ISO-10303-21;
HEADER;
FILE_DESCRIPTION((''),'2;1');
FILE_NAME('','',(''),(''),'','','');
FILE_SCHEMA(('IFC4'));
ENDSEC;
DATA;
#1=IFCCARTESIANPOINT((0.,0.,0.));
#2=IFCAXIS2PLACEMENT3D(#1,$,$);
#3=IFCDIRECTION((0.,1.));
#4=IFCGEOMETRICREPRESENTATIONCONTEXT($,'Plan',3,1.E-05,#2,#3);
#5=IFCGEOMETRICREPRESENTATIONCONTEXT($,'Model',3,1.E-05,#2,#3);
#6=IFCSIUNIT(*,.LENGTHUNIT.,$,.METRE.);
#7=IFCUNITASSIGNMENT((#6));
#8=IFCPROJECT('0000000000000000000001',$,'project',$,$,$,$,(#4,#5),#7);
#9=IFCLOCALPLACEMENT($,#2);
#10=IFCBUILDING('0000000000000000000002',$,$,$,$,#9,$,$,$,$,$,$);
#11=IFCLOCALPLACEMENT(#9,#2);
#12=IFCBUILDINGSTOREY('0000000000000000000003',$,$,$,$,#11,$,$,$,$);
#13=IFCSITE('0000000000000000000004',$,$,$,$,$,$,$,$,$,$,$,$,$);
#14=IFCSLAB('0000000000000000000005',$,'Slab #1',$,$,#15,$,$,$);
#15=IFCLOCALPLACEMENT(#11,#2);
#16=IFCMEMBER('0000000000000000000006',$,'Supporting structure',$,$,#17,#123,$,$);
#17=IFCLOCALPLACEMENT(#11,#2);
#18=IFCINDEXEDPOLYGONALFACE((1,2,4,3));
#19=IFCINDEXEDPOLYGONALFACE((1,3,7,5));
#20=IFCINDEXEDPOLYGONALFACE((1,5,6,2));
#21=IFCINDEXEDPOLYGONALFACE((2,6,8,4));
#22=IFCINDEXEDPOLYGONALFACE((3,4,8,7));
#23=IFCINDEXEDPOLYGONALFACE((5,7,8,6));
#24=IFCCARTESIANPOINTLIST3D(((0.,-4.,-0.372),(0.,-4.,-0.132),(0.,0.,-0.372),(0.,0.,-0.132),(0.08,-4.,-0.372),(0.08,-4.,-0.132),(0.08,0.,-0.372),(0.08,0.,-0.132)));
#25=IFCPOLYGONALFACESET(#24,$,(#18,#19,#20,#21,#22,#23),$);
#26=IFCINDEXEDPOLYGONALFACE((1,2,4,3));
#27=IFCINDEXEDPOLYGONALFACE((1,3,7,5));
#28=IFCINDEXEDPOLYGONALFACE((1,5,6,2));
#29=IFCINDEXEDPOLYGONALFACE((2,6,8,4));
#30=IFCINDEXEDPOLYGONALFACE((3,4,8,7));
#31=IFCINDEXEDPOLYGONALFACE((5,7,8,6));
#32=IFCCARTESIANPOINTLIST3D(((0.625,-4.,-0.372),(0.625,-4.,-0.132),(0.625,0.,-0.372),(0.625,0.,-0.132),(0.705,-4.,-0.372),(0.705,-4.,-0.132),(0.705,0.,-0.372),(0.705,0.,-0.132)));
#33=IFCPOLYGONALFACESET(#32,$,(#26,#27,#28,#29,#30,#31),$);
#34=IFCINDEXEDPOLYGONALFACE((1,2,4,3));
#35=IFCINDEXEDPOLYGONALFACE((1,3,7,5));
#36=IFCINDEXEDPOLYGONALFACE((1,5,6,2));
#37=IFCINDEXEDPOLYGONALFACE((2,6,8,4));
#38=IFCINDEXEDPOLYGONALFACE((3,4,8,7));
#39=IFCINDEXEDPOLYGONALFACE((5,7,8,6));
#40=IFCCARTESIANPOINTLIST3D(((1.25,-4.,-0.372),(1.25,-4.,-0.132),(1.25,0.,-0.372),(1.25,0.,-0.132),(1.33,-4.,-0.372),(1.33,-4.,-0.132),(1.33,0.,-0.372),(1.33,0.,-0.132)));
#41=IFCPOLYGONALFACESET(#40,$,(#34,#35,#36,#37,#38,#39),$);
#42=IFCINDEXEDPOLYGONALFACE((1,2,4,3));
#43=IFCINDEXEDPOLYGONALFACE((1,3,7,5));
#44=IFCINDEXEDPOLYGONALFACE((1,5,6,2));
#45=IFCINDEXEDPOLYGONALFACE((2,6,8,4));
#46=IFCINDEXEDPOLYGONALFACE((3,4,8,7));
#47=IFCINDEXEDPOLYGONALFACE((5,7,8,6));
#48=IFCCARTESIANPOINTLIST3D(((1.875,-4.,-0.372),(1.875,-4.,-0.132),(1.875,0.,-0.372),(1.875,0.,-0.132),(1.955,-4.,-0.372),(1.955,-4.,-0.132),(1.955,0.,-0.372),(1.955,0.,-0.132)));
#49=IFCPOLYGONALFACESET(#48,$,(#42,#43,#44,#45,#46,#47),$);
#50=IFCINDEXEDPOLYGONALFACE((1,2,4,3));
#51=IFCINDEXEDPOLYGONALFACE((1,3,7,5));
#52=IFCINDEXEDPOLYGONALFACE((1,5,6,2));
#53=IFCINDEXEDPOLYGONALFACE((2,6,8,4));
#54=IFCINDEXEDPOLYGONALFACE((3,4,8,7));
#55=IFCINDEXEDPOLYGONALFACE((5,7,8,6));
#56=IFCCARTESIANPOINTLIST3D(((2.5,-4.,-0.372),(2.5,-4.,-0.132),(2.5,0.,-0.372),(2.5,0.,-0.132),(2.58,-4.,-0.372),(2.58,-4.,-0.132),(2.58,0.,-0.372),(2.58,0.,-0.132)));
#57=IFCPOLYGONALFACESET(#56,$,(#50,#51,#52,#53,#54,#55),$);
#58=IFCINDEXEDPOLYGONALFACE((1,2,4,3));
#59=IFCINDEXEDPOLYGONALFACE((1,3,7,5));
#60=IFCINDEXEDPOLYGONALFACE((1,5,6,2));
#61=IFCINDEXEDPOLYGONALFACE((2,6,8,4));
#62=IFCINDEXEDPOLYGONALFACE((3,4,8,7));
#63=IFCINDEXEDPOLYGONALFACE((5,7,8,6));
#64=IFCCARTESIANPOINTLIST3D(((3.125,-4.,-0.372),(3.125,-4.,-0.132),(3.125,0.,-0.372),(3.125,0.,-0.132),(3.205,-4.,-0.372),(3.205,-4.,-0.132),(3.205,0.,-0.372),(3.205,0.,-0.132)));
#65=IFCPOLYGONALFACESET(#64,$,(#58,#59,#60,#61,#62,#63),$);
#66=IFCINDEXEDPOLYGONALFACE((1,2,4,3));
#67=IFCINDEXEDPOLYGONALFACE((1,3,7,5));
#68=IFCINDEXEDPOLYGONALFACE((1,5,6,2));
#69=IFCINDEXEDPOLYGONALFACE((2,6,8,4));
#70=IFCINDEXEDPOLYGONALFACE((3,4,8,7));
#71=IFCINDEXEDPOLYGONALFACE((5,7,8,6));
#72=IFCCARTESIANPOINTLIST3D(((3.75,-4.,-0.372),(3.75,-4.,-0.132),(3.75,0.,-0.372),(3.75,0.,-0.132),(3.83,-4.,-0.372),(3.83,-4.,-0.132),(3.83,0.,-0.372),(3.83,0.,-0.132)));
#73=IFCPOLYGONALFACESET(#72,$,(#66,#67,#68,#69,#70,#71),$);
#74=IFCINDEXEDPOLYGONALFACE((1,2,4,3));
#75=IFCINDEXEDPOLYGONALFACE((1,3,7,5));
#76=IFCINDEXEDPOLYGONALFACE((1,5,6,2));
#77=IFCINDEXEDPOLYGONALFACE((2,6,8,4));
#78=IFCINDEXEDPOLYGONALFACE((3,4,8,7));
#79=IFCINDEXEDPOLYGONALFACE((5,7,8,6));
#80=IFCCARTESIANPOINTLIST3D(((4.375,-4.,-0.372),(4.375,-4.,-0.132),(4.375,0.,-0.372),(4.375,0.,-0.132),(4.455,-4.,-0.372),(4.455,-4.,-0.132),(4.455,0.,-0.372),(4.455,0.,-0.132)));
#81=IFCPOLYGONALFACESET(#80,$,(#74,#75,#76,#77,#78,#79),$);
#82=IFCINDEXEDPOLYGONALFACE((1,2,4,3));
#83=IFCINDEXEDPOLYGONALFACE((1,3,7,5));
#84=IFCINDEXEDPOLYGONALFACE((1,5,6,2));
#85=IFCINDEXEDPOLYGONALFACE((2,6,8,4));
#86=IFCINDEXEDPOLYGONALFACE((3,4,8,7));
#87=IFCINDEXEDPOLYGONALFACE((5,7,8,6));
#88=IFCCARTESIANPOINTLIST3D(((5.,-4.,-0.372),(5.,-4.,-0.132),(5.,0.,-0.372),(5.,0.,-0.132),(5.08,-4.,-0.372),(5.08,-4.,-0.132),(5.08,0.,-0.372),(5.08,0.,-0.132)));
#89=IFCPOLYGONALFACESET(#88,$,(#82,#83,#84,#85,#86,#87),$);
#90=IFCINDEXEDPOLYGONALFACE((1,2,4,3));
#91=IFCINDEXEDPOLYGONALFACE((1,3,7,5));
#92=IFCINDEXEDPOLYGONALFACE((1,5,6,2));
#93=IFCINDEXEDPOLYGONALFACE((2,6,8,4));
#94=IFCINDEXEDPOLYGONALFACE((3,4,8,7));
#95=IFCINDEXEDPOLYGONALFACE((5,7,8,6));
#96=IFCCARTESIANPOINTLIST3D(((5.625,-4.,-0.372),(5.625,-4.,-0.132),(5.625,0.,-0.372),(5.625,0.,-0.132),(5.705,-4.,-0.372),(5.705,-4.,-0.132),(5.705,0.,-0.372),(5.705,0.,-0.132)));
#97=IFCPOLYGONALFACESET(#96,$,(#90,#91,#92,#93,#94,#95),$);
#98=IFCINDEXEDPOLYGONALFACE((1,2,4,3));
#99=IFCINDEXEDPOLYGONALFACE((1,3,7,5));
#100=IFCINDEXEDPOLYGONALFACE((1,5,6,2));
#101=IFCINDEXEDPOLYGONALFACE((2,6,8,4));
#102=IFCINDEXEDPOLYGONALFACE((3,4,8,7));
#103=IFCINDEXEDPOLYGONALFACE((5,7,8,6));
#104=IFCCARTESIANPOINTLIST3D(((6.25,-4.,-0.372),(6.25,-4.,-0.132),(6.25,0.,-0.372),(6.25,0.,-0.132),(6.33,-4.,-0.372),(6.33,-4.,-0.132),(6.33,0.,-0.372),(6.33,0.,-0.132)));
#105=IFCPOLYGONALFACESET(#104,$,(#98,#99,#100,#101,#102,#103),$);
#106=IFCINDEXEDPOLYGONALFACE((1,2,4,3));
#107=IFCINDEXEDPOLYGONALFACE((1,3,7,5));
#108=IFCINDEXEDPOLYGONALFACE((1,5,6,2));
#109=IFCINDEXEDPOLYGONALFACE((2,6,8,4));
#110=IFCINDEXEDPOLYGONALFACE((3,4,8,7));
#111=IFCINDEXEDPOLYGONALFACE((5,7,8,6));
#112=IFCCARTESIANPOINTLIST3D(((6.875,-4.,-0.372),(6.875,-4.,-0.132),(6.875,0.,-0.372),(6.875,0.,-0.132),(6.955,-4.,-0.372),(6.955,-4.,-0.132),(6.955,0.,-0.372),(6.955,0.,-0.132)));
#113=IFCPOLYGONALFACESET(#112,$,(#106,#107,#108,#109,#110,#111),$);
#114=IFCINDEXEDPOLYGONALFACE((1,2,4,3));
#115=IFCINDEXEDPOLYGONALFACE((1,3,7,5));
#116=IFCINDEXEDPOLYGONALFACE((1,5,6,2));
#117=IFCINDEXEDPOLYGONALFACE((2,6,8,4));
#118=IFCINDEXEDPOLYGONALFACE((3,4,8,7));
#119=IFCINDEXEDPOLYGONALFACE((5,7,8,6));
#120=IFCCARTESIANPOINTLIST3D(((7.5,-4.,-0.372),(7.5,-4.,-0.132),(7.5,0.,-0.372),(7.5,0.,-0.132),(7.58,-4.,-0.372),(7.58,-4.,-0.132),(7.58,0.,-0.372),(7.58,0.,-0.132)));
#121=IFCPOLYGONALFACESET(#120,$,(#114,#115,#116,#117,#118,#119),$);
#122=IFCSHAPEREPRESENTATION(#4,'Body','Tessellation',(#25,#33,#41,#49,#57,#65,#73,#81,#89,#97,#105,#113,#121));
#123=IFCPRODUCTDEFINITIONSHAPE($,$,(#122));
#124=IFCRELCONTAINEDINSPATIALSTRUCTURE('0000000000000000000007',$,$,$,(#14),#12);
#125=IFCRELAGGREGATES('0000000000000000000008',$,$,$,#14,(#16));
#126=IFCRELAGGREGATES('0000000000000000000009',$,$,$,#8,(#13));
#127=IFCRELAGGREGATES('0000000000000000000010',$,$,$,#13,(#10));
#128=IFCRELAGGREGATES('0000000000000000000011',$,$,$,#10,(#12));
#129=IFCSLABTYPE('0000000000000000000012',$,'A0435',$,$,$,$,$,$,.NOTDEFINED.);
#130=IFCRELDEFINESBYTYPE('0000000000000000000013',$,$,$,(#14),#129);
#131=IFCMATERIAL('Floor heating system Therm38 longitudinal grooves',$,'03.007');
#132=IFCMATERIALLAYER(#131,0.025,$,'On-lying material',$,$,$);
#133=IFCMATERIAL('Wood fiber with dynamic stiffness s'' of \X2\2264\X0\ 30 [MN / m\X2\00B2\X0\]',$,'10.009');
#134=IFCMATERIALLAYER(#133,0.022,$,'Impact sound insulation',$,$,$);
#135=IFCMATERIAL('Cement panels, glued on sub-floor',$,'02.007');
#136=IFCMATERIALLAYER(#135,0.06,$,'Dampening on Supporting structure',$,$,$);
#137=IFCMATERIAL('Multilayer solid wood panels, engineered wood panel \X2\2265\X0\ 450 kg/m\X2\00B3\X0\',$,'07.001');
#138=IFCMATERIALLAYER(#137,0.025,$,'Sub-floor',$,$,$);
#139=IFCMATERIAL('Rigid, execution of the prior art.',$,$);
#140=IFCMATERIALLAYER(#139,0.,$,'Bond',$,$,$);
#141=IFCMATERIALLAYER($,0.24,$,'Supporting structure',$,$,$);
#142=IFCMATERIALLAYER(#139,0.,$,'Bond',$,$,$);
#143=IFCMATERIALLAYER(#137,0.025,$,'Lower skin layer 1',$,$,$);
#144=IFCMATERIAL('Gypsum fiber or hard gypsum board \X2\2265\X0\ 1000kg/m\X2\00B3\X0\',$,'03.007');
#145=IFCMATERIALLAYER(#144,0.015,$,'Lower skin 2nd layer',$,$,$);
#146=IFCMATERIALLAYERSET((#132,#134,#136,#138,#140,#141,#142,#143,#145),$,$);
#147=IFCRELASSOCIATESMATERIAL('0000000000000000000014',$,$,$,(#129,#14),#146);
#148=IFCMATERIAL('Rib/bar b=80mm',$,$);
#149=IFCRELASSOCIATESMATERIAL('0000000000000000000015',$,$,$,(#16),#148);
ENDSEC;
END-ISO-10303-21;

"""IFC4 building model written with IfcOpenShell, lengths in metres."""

from ifc_helpers import new_model, si_unit, direction, frame, frame_2d, origin, place, context, project, spatial, rectangle, extrude, material, layer, layer_set, type_object, element, aggregate, save


model = new_model("IFC4")

# Units and contexts
plan_context = context("Plan", 3, precision=1e-05, world=origin(), true_north=direction((0.0, 1.0)))
model_context = context("Model", 3, precision=1e-05, world=origin(), true_north=direction((0.0, 1.0)))
ifc_project = project(units=[si_unit("LENGTHUNIT", "METRE")], contexts=[plan_context, model_context])

# Site, building, storey
site = spatial("IfcSite", under=ifc_project)
building_placement = place(None, origin())
building = spatial("IfcBuilding", under=site, at=building_placement)
storey_placement = place(building_placement, origin())
storey = spatial("IfcBuildingStorey", under=building, at=storey_placement)

# Slab, member
ifc_material_1 = material(Name="Floor heating system Therm38 longitudinal grooves", Category="03.007")
ifc_layer_1 = layer(ifc_material_1, 0.025, Name="On-lying material")
ifc_material_2 = material(Name="Wood fiber with dynamic stiffness s' of ≤ 30 [MN / m²]", Category="10.009")
ifc_layer_2 = layer(ifc_material_2, 0.022, Name="Impact sound insulation")
ifc_material_3 = material(Name="Cement panels, glued on sub-floor", Category="02.007")
ifc_layer_3 = layer(ifc_material_3, 0.06, Name="Dampening on Supporting structure")
ifc_material_4 = material(Name="Multilayer solid wood panels, engineered wood panel ≥ 450 kg/m³", Category="07.001")
ifc_layer_4 = layer(ifc_material_4, 0.025, Name="Sub-floor")
ifc_material_5 = material(Name="Rigid, execution of the prior art.")
ifc_layer_5 = layer(ifc_material_5, 0.0, Name="Bond")
ifc_layer_6 = layer(None, 0.24, Name="Supporting structure")
ifc_layer_7 = layer(ifc_material_5, 0.0, Name="Bond")
ifc_layer_8 = layer(ifc_material_4, 0.025, Name="Lower skin layer 1")
ifc_material_6 = material(Name="Gypsum fiber or hard gypsum board ≥ 1000kg/m³", Category="03.007")
ifc_layer_9 = layer(ifc_material_6, 0.015, Name="Lower skin 2nd layer")
ifc_layer_set = layer_set([ifc_layer_1, ifc_layer_2, ifc_layer_3, ifc_layer_4, ifc_layer_5, ifc_layer_6, ifc_layer_7, ifc_layer_8, ifc_layer_9])
slab_type = type_object("IfcSlabType", Name="A0435", PredefinedType="NOTDEFINED", material=ifc_layer_set)
slab_placement = place(None, frame((0.0, 0.0, 0.0), z_axis=(0.0, 0.0, -1.0), x_axis=(1.0, 0.0, 0.0)))
slab = element("IfcSlab", 1, at=slab_placement, inside=storey, type_object=slab_type, material=ifc_layer_set, Name="Slab #1")
ifc_material_7 = material(Name="Rib/bar b=80mm")
member_1_placement = place(slab_placement, origin())
member_1 = element("IfcMember", 2, at=member_1_placement, material=ifc_material_7, Name="Supporting structure", context=plan_context, shape_type="SweptSolid", body=[
    extrude(rectangle(XDim=0.08, YDim=0.24, at=frame_2d((0.04, 0.12), x_axis=(1.0, 0.0))), frame((0.0, 4.0, 0.132), z_axis=(0.0, -1.0, 0.0), x_axis=(1.0, 0.0, 0.0)), (0.0, 0.0, 1.0), 4.0),
    extrude(rectangle(XDim=0.08, YDim=0.24, at=frame_2d((0.04, 0.12), x_axis=(1.0, 0.0))), frame((0.625, 4.0, 0.132), z_axis=(0.0, -1.0, 0.0), x_axis=(1.0, 0.0, 0.0)), (0.0, 0.0, 1.0), 4.0),
    extrude(rectangle(XDim=0.08, YDim=0.24, at=frame_2d((0.04, 0.12), x_axis=(1.0, 0.0))), frame((1.25, 4.0, 0.132), z_axis=(0.0, -1.0, 0.0), x_axis=(1.0, 0.0, 0.0)), (0.0, 0.0, 1.0), 4.0),
    extrude(rectangle(XDim=0.08, YDim=0.24, at=frame_2d((0.04, 0.12), x_axis=(1.0, 0.0))), frame((1.875, 4.0, 0.132), z_axis=(0.0, -1.0, 0.0), x_axis=(1.0, 0.0, 0.0)), (0.0, 0.0, 1.0), 4.0),
    extrude(rectangle(XDim=0.08, YDim=0.24, at=frame_2d((0.04, 0.12), x_axis=(1.0, 0.0))), frame((2.5, 4.0, 0.132), z_axis=(0.0, -1.0, 0.0), x_axis=(1.0, 0.0, 0.0)), (0.0, 0.0, 1.0), 4.0),
    extrude(rectangle(XDim=0.08, YDim=0.24, at=frame_2d((0.04, 0.12), x_axis=(1.0, 0.0))), frame((3.125, 4.0, 0.132), z_axis=(0.0, -1.0, 0.0), x_axis=(1.0, 0.0, 0.0)), (0.0, 0.0, 1.0), 4.0),
    extrude(rectangle(XDim=0.08, YDim=0.24, at=frame_2d((0.04, 0.12), x_axis=(1.0, 0.0))), frame((3.75, 4.0, 0.132), z_axis=(0.0, -1.0, 0.0), x_axis=(1.0, 0.0, 0.0)), (0.0, 0.0, 1.0), 4.0),
    extrude(rectangle(XDim=0.08, YDim=0.24, at=frame_2d((0.04, 0.12), x_axis=(1.0, 0.0))), frame((4.375, 4.0, 0.132), z_axis=(0.0, -1.0, 0.0), x_axis=(1.0, 0.0, 0.0)), (0.0, 0.0, 1.0), 4.0),
    extrude(rectangle(XDim=0.08, YDim=0.24, at=frame_2d((0.04, 0.12), x_axis=(1.0, 0.0))), frame((5.0, 4.0, 0.132), z_axis=(0.0, -1.0, 0.0), x_axis=(1.0, 0.0, 0.0)), (0.0, 0.0, 1.0), 4.0),
    extrude(rectangle(XDim=0.08, YDim=0.24, at=frame_2d((0.04, 0.12), x_axis=(1.0, 0.0))), frame((5.625, 4.0, 0.132), z_axis=(0.0, -1.0, 0.0), x_axis=(1.0, 0.0, 0.0)), (0.0, 0.0, 1.0), 4.0),
    extrude(rectangle(XDim=0.08, YDim=0.24, at=frame_2d((0.04, 0.12), x_axis=(1.0, 0.0))), frame((6.25, 4.0, 0.132), z_axis=(0.0, -1.0, 0.0), x_axis=(1.0, 0.0, 0.0)), (0.0, 0.0, 1.0), 4.0),
    extrude(rectangle(XDim=0.08, YDim=0.24, at=frame_2d((0.04, 0.12), x_axis=(1.0, 0.0))), frame((6.875, 4.0, 0.132), z_axis=(0.0, -1.0, 0.0), x_axis=(1.0, 0.0, 0.0)), (0.0, 0.0, 1.0), 4.0),
    extrude(rectangle(XDim=0.08, YDim=0.24, at=frame_2d((0.04, 0.12), x_axis=(1.0, 0.0))), frame((7.5, 4.0, 0.132), z_axis=(0.0, -1.0, 0.0), x_axis=(1.0, 0.0, 0.0)), (0.0, 0.0, 1.0), 4.0),
])
aggregate(slab, [member_1])

save(model, "model.ifc")
